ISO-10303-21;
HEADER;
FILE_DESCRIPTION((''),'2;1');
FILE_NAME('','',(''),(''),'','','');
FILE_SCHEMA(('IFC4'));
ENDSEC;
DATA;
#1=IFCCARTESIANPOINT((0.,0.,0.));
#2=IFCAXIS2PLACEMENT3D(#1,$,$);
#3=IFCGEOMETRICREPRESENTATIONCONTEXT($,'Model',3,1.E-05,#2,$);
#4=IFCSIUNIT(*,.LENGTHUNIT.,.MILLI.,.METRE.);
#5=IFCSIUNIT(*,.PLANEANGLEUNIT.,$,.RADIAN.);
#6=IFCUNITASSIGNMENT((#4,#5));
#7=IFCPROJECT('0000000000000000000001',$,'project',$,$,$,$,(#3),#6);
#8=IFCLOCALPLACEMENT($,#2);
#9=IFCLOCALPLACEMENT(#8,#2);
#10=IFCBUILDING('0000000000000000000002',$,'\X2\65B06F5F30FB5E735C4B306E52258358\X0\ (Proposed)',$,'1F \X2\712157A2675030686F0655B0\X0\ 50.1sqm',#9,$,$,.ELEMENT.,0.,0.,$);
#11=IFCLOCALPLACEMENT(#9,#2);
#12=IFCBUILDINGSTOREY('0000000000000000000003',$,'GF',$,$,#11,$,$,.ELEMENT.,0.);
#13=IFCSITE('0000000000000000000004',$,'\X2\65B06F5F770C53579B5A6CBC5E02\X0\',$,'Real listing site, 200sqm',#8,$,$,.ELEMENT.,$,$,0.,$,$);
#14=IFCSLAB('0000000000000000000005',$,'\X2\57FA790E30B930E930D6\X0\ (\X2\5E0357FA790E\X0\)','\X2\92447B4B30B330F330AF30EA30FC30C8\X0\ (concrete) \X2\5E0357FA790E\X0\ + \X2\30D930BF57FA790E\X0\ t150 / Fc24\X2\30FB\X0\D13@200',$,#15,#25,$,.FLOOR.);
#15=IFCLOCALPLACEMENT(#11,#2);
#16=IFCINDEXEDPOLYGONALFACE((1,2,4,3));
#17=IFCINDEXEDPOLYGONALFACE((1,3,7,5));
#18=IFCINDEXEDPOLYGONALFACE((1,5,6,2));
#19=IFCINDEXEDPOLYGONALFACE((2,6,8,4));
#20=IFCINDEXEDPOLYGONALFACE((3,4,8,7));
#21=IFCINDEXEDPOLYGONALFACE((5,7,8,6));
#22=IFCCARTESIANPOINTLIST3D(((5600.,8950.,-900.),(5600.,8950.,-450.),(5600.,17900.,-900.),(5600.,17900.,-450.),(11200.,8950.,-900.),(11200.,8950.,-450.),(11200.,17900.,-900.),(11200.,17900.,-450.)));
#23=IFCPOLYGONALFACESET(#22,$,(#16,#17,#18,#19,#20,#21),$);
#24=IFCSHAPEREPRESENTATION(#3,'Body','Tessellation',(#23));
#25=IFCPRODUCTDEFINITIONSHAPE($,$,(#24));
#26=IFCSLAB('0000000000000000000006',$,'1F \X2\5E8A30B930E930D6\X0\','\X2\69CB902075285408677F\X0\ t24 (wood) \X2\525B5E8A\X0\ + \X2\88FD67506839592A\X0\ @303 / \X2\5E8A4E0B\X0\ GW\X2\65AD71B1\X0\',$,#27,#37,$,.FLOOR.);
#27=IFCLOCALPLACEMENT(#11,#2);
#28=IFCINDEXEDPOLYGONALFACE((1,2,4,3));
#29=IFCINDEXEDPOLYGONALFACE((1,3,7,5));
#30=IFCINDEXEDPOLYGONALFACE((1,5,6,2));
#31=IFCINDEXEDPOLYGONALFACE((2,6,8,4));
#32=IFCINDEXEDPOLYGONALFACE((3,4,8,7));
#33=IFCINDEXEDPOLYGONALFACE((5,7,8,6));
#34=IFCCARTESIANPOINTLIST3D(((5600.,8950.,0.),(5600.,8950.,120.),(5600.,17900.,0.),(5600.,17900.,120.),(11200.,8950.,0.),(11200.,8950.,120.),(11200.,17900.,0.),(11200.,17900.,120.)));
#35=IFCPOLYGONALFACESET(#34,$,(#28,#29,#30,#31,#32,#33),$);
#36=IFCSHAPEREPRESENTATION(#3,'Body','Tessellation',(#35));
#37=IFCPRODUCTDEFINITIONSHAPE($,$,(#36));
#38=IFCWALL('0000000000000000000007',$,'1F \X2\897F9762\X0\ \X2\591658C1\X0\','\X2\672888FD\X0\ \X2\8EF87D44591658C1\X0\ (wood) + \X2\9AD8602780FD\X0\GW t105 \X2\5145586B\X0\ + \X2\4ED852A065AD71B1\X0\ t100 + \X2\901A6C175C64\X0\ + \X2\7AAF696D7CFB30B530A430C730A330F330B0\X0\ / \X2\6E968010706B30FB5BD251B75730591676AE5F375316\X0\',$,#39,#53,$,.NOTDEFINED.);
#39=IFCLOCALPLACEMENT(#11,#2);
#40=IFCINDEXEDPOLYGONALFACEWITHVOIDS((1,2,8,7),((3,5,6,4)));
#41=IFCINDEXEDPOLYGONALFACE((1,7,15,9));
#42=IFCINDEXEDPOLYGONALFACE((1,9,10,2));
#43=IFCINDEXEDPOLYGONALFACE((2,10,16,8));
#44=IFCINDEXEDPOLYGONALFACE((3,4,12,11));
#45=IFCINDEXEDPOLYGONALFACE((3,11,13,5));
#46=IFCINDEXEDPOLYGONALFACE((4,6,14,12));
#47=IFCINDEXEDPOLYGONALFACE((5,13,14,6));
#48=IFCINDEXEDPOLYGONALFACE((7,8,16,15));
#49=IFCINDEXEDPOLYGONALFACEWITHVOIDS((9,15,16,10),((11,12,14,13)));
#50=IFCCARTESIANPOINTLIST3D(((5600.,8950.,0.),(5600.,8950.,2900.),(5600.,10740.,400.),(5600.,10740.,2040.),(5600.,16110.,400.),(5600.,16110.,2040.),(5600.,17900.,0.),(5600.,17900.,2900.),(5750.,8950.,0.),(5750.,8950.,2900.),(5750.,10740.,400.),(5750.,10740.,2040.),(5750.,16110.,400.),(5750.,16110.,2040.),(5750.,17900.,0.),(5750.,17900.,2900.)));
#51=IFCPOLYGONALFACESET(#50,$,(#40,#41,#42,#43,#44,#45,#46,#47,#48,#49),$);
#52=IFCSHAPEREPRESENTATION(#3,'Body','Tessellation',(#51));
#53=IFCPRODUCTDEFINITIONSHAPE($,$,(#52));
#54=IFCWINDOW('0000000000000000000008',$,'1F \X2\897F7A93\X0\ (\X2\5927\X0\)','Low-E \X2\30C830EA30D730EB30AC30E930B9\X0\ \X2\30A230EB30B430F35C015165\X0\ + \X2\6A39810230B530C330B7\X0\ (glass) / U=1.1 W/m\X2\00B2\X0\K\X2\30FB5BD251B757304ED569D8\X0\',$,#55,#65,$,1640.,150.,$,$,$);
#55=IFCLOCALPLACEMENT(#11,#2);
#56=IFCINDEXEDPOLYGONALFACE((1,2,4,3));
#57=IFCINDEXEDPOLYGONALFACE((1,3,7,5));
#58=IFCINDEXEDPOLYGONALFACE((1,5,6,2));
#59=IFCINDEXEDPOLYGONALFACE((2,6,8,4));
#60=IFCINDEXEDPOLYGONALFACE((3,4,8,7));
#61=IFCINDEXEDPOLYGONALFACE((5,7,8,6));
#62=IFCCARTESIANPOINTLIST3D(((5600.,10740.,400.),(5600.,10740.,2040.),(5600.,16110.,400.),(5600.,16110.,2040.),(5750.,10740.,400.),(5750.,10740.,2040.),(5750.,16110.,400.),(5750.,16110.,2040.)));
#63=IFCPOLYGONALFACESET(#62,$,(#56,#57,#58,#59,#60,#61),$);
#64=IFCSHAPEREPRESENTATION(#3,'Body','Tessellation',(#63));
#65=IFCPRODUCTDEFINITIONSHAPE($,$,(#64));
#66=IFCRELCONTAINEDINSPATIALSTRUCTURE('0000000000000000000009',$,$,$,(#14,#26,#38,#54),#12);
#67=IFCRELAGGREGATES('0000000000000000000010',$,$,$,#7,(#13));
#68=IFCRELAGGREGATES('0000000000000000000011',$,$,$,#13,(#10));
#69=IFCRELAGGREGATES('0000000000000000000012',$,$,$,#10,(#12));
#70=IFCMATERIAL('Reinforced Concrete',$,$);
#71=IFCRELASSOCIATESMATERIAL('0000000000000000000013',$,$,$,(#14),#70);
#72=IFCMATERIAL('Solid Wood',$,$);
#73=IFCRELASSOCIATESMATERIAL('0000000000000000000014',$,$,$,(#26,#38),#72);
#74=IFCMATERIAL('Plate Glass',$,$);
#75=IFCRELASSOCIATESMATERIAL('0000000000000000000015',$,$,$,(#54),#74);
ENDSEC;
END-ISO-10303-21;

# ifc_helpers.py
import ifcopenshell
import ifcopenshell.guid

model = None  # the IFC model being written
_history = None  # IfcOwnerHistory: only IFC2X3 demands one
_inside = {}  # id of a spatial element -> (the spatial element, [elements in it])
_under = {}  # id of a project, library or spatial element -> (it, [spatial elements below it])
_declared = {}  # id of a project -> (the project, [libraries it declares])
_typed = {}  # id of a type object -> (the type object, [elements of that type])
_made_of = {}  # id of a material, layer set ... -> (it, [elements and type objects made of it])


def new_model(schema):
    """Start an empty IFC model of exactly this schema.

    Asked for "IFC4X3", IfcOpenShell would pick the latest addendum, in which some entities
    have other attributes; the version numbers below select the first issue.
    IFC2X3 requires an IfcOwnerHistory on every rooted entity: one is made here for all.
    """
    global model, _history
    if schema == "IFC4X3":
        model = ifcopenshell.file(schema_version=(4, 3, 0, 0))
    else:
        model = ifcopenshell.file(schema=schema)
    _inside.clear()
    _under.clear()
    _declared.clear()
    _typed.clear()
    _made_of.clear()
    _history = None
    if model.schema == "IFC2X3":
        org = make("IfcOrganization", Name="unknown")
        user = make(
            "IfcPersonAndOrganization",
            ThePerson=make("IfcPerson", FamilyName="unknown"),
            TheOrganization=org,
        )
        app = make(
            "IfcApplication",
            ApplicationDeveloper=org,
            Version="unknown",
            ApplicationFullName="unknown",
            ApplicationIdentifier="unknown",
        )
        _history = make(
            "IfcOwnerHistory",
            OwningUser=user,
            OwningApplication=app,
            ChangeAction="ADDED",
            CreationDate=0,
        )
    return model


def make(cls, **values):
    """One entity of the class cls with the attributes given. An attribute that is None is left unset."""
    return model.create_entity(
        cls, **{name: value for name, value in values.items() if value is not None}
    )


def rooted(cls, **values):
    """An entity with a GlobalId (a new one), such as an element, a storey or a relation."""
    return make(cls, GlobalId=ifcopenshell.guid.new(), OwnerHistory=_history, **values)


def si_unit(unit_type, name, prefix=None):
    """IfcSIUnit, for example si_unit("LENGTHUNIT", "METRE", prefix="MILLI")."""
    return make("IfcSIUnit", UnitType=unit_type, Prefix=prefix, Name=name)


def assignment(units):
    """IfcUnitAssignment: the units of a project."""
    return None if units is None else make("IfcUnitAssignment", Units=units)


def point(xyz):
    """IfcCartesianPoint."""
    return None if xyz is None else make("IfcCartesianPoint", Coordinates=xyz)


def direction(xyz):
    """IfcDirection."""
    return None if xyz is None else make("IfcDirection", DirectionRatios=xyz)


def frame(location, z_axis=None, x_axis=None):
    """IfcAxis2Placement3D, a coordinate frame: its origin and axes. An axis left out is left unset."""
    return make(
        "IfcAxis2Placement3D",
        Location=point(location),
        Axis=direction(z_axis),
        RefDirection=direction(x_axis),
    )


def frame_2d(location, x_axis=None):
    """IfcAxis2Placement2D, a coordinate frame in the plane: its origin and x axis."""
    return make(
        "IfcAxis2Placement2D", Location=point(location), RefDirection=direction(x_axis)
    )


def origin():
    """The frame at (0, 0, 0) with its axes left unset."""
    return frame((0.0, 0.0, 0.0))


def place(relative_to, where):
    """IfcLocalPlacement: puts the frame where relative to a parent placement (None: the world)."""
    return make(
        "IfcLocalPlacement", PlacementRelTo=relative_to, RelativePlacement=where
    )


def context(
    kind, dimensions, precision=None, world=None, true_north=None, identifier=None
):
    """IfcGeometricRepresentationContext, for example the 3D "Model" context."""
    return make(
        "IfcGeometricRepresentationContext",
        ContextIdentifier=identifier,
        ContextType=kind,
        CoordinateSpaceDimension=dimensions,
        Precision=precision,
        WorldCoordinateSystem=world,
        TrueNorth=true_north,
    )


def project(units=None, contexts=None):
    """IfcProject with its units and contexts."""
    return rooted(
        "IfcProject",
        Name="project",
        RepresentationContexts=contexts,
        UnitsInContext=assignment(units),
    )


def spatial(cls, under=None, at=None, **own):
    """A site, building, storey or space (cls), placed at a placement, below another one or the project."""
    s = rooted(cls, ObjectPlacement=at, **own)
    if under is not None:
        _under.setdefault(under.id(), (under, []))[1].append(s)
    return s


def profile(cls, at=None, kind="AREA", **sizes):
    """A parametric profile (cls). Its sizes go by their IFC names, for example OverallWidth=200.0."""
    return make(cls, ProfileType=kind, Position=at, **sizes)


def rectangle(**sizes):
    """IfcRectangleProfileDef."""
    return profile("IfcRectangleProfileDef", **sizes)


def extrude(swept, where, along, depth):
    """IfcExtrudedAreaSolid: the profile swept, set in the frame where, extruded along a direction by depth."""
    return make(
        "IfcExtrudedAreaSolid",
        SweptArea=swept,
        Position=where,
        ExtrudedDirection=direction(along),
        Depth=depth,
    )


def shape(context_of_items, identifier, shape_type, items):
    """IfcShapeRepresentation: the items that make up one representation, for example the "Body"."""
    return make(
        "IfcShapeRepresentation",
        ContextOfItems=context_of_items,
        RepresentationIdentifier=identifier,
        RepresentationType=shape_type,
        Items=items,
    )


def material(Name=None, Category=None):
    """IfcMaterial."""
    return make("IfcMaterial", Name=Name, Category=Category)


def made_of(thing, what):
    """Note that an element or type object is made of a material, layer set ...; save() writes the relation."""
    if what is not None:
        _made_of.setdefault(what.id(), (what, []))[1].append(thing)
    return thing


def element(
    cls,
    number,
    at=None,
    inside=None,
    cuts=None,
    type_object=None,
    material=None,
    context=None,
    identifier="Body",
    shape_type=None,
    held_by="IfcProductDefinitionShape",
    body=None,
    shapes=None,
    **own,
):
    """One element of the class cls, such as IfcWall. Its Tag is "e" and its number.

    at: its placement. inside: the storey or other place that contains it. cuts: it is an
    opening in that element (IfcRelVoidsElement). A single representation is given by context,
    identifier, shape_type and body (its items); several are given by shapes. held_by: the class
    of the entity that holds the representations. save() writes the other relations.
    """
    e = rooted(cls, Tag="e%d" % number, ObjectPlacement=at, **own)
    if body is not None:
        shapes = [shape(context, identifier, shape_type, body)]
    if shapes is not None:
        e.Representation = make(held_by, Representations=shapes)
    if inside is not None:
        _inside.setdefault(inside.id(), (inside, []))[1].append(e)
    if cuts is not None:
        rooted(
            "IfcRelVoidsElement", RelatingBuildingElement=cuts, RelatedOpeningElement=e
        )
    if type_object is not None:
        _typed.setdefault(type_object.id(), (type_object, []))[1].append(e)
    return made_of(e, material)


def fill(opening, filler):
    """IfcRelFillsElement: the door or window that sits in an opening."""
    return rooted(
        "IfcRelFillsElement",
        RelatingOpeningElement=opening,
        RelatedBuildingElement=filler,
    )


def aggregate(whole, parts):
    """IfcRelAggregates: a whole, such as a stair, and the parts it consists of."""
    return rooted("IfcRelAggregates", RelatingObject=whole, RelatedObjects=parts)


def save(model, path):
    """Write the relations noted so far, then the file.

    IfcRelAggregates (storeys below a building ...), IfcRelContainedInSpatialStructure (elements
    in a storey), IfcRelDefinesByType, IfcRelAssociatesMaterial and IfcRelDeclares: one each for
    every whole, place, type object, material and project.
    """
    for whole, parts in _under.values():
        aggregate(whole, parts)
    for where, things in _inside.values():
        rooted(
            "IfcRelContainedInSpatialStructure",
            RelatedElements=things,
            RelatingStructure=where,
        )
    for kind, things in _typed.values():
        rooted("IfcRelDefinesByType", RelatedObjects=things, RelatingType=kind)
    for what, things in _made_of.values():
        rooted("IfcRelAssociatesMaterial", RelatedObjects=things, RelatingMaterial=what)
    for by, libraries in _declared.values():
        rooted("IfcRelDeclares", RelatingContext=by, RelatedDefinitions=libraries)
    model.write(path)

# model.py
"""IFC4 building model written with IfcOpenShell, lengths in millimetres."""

from ifc_helpers import new_model, si_unit, frame, frame_2d, origin, place, context, project, spatial, rectangle, extrude, material, element, fill, save


model = new_model("IFC4")

# Units and contexts
model_context = context("Model", 3, precision=1e-05, world=origin())
ifc_project = project(units=[si_unit("LENGTHUNIT", "METRE", prefix="MILLI"), si_unit("PLANEANGLEUNIT", "RADIAN")], contexts=[model_context])

# Site, building, storey
site_placement = place(None, origin())
site = spatial("IfcSite", under=ifc_project, at=site_placement, Name="新潟県南魚沼市", ObjectType="Real listing site, 200sqm", CompositionType="ELEMENT", RefElevation=0.0)
building_placement = place(site_placement, origin())
building = spatial("IfcBuilding", under=site, at=building_placement, Name="新潟・平屋の別荘 (Proposed)", ObjectType="1F 無垢材と漆喰 50.1sqm", CompositionType="ELEMENT", ElevationOfRefHeight=0.0, ElevationOfTerrain=0.0)
storey_placement = place(building_placement, origin())
storey = spatial("IfcBuildingStorey", under=building, at=storey_placement, Name="GF", CompositionType="ELEMENT", Elevation=0.0)

# Shared definitions
ifc_material_1 = material(Name="Solid Wood")

# Slabs
ifc_material_2 = material(Name="Reinforced Concrete")
slab_1_placement = place(storey_placement, frame((2800.0, 4475.0, -450.0)))
element("IfcSlab", 1, at=slab_1_placement, inside=storey, material=ifc_material_2, Name="基礎スラブ (布基礎)", Description="鉄筋コンクリート (concrete) 布基礎 + ベタ基礎 t150 / Fc24・D13@200", PredefinedType="FLOOR", context=model_context, shape_type="SweptSolid", body=[
    extrude(rectangle(XDim=5600.0, YDim=8950.0, at=frame_2d((2800.0, 4475.0))), frame((2800.0, 4475.0, -450.0)), (0.0, 0.0, 1.0), 450.0),
])
slab_2_placement = place(storey_placement, frame((2800.0, 4475.0, 0.0)))
element("IfcSlab", 2, at=slab_2_placement, inside=storey, material=ifc_material_1, Name="1F 床スラブ", Description="構造用合板 t24 (wood) 剛床 + 製材根太 @303 / 床下 GW断熱", PredefinedType="FLOOR", context=model_context, shape_type="SweptSolid", body=[
    extrude(rectangle(XDim=5600.0, YDim=8950.0, at=frame_2d((2800.0, 4475.0))), frame((2800.0, 4475.0, 0.0)), (0.0, 0.0, 1.0), 120.0),
])

# Shared definitions
ifc_material_3 = material(Name="Plate Glass")

# Wall, opening, window
wall_1_placement = place(storey_placement, frame((2800.0, 4475.0, 0.0)))
wall_1 = element("IfcWall", 3, at=wall_1_placement, inside=storey, material=ifc_material_1, Name="1F 西面 外壁", Description="木製 軸組外壁 (wood) + 高性能GW t105 充填 + 付加断熱 t100 + 通気層 + 窯業系サイディング / 準耐火・寒冷地外皮強化", PredefinedType="NOTDEFINED", context=model_context, shape_type="SweptSolid", body=[
    extrude(rectangle(XDim=150.0, YDim=8950.0, at=frame_2d((75.0, 4475.0))), frame((2800.0, 4475.0, 0.0)), (0.0, 0.0, 1.0), 2900.0),
])
opening_1_placement = place(storey_placement, frame((2800.0, 5370.0, 200.0)))
opening_1 = element("IfcOpeningElement", 4, at=opening_1_placement, cuts=wall_1, PredefinedType="NOTDEFINED", context=model_context, shape_type="SweptSolid", body=[
    extrude(rectangle(XDim=150.0, YDim=5370.0, at=frame_2d((75.0, 2685.0))), frame((2800.0, 5370.0, 200.0)), (0.0, 0.0, 1.0), 1640.0),
])
window_1_placement = place(storey_placement, frame((2800.0, 5370.0, 200.0)))
window_1 = element("IfcWindow", 5, at=window_1_placement, inside=storey, material=ifc_material_3, Name="1F 西窓 (大)", Description="Low-E トリプルガラス アルゴン封入 + 樹脂サッシ (glass) / U=1.1 W/m²K・寒冷地仕様", OverallHeight=1640.0, OverallWidth=150.0, context=model_context, shape_type="SweptSolid", body=[
    extrude(rectangle(XDim=150.0, YDim=5370.0, at=frame_2d((75.0, 2685.0))), frame((2800.0, 5370.0, 200.0)), (0.0, 0.0, 1.0), 1640.0),
])
fill(opening_1, window_1)

save(model, "model.ifc")
